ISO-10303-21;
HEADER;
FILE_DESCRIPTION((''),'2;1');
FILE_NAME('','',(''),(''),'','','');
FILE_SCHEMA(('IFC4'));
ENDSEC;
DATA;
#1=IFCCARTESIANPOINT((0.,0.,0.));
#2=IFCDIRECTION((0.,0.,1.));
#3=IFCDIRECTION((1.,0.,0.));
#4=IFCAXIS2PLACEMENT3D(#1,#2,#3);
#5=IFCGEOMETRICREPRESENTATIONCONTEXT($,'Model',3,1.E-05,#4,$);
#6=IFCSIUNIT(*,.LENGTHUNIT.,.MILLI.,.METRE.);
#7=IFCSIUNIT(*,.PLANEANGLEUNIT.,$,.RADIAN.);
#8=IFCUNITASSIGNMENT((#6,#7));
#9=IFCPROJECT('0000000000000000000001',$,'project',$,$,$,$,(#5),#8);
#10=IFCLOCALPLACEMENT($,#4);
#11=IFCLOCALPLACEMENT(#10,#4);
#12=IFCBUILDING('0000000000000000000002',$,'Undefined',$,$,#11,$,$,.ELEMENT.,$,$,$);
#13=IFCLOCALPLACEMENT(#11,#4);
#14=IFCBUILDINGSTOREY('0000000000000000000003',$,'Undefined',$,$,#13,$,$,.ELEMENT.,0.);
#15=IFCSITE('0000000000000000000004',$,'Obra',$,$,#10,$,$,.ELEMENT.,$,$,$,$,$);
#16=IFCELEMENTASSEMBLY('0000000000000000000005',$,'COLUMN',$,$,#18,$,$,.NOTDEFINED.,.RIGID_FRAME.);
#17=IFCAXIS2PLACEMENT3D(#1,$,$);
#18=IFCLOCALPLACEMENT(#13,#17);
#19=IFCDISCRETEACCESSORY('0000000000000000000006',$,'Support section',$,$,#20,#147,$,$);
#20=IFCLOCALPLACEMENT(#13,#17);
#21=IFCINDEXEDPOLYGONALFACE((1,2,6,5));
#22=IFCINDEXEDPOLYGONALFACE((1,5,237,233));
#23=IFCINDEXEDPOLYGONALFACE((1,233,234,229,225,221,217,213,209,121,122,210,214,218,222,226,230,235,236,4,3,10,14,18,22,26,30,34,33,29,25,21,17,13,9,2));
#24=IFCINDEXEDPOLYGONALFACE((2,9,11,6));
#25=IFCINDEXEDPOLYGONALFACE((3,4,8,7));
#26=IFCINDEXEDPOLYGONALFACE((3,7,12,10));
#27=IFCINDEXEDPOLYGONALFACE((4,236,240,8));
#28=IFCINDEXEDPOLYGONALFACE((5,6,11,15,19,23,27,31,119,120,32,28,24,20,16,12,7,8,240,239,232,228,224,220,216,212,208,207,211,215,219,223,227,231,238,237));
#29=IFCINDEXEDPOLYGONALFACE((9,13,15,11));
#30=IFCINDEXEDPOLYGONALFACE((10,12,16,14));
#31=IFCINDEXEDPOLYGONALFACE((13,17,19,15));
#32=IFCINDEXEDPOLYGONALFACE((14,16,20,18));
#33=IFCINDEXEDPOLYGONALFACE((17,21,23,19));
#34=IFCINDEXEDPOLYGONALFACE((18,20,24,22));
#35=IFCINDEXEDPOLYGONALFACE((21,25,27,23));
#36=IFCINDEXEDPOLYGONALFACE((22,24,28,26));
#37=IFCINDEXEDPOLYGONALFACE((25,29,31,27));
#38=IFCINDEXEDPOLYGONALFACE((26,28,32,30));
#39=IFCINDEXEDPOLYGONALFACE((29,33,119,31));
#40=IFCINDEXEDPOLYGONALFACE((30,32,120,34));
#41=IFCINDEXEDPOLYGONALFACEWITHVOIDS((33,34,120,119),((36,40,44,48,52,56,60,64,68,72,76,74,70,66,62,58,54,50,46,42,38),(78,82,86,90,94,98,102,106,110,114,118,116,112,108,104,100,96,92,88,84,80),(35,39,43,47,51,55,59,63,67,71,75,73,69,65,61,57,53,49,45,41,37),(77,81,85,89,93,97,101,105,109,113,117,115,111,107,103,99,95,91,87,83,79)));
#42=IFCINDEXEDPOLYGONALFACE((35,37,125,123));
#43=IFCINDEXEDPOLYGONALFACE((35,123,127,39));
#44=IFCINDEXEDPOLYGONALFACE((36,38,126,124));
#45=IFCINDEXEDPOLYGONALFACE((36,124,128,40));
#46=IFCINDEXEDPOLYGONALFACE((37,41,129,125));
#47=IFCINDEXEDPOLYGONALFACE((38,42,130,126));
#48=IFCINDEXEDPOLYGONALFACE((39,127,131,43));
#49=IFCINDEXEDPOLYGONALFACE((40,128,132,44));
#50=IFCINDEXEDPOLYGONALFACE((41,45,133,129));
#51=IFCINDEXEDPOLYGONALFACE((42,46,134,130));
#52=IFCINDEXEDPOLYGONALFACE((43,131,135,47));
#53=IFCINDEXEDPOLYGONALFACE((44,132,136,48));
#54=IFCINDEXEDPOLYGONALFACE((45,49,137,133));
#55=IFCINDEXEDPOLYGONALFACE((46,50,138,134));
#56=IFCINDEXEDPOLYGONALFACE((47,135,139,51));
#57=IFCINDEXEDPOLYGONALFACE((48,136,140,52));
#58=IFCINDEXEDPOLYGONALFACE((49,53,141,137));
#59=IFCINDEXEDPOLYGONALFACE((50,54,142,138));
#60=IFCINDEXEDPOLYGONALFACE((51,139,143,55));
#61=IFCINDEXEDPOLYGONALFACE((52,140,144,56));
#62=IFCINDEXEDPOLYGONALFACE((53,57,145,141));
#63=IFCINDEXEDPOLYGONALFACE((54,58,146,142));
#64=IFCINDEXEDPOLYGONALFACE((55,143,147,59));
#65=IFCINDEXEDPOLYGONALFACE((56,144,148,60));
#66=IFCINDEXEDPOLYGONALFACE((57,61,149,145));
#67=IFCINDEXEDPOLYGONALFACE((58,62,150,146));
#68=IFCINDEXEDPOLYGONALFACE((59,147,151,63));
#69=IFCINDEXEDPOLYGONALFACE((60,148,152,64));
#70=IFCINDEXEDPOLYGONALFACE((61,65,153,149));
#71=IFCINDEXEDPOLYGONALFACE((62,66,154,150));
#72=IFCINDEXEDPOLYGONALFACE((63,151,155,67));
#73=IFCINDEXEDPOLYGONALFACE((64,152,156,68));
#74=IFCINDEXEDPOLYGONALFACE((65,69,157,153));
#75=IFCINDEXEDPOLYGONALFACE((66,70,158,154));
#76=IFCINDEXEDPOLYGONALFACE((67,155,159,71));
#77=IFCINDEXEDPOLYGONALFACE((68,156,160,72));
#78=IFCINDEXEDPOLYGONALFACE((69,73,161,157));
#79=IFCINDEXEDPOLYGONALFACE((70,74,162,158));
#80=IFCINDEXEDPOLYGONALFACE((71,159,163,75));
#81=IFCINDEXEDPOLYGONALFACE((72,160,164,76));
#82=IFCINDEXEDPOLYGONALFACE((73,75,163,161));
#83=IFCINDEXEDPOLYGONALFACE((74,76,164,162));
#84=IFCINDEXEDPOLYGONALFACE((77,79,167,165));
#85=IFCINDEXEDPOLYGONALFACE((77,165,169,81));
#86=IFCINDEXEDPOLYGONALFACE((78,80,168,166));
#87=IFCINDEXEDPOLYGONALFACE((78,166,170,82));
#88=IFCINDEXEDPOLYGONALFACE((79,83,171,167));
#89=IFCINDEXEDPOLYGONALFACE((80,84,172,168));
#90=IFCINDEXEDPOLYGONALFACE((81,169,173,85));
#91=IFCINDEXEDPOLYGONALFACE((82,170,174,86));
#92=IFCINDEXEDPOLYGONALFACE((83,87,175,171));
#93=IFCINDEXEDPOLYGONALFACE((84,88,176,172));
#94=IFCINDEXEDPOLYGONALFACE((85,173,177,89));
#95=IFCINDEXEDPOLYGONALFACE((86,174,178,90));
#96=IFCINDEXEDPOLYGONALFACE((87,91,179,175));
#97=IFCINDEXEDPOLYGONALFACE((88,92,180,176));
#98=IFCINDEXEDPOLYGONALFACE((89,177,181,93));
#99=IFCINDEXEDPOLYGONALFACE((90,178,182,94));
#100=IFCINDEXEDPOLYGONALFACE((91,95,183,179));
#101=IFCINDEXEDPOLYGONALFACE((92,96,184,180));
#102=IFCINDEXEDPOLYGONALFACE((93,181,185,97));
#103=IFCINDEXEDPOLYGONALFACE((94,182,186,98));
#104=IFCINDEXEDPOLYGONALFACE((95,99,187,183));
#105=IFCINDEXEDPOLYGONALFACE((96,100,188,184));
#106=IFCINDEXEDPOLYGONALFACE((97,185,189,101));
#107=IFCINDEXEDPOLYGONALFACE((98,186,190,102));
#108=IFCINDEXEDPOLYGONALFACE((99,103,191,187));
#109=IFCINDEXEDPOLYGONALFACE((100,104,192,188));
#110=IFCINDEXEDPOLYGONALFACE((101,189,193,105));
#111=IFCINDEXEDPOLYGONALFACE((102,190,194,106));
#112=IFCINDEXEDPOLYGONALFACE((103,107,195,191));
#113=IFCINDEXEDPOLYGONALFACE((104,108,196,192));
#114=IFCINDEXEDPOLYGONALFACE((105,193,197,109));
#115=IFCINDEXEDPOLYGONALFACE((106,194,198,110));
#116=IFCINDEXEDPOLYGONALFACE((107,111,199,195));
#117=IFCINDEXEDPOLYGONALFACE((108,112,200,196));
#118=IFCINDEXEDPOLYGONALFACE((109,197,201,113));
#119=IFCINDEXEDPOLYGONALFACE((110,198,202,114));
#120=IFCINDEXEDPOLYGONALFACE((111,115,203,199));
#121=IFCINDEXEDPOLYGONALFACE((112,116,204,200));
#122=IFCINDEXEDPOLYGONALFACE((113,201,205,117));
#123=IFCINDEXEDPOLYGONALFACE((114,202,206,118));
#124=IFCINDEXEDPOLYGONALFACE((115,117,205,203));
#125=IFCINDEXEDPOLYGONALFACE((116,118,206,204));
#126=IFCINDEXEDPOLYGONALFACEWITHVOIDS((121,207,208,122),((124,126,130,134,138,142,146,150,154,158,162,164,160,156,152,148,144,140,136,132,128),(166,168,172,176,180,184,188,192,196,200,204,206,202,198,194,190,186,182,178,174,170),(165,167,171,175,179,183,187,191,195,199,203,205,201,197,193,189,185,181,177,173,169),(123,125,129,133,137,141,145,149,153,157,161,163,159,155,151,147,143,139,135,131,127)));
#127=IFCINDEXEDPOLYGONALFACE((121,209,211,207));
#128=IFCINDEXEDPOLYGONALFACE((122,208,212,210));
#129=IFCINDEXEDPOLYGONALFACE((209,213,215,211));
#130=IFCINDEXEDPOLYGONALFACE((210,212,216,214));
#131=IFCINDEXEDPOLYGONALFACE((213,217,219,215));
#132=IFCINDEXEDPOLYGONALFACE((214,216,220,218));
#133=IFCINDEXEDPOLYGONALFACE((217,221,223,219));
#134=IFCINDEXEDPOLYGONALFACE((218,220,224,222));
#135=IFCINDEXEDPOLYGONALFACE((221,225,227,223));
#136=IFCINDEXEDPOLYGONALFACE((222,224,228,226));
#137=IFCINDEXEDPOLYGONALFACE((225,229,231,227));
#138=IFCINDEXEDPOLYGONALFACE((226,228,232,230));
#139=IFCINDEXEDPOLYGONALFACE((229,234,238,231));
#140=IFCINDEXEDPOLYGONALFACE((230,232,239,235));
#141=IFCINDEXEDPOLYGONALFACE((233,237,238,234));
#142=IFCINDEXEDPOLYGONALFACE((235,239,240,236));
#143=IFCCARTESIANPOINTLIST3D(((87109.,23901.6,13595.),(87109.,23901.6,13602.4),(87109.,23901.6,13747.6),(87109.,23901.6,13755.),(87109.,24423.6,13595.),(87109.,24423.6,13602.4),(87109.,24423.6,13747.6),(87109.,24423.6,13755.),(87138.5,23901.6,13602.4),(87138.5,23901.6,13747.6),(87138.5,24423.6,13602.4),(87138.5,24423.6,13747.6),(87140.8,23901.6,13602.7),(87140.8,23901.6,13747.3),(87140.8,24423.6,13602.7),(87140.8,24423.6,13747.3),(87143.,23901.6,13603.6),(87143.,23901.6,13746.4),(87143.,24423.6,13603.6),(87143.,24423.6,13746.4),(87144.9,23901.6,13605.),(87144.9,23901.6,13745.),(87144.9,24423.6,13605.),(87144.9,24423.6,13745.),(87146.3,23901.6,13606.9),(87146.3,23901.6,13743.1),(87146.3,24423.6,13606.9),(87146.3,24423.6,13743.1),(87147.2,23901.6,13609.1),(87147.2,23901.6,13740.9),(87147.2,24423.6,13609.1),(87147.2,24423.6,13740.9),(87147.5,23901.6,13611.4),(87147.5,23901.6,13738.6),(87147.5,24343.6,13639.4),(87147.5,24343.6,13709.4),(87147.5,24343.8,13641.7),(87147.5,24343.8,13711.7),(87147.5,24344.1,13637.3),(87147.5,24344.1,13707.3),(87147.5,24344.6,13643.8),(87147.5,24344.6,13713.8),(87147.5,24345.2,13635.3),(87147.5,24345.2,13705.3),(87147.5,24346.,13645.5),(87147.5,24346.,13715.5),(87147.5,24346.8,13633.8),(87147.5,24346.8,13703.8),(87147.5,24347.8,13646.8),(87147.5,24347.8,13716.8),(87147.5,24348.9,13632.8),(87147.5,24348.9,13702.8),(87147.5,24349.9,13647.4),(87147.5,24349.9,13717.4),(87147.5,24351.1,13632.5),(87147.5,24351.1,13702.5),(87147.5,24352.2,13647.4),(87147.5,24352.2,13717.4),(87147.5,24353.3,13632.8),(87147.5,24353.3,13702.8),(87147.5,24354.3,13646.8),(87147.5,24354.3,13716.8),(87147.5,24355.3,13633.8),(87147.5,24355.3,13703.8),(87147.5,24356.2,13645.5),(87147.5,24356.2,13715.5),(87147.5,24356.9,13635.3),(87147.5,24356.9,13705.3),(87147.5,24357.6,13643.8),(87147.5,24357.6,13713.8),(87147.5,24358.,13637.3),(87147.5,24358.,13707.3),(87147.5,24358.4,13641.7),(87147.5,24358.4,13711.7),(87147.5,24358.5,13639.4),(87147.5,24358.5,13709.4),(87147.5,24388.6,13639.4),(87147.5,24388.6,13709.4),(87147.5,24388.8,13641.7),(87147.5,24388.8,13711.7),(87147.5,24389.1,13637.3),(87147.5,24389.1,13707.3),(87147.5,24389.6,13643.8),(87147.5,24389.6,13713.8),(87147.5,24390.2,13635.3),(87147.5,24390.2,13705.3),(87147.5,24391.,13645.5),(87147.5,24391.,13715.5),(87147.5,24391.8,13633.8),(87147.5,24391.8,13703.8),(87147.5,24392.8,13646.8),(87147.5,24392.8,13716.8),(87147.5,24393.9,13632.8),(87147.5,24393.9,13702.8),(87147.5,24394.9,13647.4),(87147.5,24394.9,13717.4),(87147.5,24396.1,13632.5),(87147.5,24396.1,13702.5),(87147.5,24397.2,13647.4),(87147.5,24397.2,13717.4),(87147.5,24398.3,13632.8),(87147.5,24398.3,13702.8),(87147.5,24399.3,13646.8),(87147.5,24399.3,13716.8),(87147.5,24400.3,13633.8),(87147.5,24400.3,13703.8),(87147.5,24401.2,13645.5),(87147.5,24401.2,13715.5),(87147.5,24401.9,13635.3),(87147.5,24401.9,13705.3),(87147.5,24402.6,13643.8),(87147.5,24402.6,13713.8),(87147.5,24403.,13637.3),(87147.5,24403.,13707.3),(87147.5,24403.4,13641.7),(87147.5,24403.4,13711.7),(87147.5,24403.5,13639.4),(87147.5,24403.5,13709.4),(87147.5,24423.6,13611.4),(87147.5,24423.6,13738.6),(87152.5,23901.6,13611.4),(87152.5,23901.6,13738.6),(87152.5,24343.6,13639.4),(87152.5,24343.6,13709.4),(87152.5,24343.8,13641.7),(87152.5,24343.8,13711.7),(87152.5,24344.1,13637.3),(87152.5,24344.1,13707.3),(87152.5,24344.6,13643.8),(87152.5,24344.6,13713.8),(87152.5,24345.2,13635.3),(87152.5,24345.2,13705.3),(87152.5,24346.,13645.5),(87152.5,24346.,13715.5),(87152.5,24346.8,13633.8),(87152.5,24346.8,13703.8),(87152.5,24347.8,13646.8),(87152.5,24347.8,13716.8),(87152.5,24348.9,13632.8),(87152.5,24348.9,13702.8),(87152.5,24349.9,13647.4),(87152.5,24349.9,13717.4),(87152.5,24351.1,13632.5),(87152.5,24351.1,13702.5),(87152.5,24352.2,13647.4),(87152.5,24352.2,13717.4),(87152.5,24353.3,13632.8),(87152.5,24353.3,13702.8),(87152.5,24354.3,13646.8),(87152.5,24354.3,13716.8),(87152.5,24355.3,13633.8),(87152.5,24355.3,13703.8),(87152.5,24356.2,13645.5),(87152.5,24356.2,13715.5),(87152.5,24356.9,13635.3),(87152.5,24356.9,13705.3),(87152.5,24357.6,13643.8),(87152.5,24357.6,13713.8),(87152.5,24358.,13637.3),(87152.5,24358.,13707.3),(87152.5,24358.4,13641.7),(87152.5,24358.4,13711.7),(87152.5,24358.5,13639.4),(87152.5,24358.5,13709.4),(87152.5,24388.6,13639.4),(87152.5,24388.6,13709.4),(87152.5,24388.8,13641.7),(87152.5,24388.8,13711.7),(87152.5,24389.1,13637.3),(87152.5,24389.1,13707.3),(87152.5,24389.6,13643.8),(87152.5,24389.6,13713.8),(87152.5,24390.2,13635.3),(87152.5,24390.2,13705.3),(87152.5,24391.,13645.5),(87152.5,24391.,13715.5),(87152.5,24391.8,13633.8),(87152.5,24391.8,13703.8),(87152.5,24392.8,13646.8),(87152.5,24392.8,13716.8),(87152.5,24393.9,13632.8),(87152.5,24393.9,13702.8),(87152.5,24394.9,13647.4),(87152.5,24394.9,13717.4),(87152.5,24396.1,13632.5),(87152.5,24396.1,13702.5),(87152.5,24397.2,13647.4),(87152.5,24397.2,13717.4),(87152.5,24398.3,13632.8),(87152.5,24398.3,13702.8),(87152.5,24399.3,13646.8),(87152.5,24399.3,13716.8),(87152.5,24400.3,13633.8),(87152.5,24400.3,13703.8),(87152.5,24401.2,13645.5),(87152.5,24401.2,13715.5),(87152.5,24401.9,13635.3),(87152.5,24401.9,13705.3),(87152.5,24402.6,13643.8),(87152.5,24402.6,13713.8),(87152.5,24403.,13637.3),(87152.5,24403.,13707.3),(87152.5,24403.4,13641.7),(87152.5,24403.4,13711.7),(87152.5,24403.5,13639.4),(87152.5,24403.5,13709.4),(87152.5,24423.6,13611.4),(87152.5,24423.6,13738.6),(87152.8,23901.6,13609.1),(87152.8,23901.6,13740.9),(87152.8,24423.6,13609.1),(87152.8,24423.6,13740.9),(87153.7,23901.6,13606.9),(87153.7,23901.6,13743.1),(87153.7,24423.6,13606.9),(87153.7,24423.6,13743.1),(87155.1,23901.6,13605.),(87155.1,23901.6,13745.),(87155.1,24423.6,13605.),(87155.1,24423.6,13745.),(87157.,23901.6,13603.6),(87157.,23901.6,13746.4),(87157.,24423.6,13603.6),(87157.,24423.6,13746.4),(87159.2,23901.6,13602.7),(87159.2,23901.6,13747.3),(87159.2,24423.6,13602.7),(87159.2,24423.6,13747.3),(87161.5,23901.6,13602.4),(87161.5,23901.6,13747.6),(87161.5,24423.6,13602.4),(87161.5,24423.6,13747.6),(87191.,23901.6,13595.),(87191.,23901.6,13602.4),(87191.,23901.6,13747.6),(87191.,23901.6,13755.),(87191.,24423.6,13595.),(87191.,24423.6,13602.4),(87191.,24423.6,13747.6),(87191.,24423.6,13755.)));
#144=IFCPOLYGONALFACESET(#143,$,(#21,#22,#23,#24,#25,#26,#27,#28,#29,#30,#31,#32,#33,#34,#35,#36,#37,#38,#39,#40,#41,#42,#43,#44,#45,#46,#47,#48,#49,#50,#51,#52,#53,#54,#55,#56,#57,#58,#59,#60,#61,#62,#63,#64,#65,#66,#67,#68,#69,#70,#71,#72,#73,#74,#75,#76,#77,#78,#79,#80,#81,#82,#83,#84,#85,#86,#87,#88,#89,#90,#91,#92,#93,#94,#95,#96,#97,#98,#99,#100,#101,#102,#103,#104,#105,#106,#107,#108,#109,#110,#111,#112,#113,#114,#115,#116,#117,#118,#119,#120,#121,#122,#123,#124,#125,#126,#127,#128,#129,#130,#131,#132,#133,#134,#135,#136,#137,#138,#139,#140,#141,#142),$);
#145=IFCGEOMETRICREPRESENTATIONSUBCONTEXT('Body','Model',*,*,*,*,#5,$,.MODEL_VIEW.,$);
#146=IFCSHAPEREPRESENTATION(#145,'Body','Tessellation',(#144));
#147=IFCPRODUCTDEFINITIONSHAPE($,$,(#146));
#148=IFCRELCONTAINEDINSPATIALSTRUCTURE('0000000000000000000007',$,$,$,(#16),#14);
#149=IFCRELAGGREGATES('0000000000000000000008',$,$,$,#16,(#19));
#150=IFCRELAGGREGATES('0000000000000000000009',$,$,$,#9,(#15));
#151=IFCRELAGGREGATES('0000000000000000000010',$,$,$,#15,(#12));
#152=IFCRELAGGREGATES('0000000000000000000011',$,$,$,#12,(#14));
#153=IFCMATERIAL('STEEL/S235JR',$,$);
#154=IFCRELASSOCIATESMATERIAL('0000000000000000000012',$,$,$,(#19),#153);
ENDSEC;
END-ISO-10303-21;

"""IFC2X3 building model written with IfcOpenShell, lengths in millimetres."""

from ifc_helpers import new_model, si_unit, frame, origin_with_axes, origin_2d_with_axis, place, context, subcontext, project, spatial, circle, i_section, extrude, clip, halfspace, source, transform, mapped, material, element, aggregate, save


model = new_model("IFC2X3")

# Units and contexts
model_context = context("Model", 3, precision=1e-05, world=origin_with_axes())
body_context = subcontext(model_context, "Body", "Model", "MODEL_VIEW")
ifc_project = project(units=[si_unit("LENGTHUNIT", "METRE", prefix="MILLI"), si_unit("PLANEANGLEUNIT", "RADIAN")], contexts=[model_context])

# Site, building, storey
site_placement = place(None, origin_with_axes())
site = spatial("IfcSite", under=ifc_project, at=site_placement, Name="Obra", CompositionType="ELEMENT")
building_placement = place(site_placement, origin_with_axes())
building = spatial("IfcBuilding", under=site, at=building_placement, Name="Undefined", CompositionType="ELEMENT")
storey_placement = place(building_placement, origin_with_axes())
storey = spatial("IfcBuildingStorey", under=building, at=storey_placement, Name="Undefined", CompositionType="ELEMENT", Elevation=0.0)

# Shared definitions
ifc_material_1 = material(Name="STEEL/S235JR")

# Element assembly
assembly_1_placement = place(storey_placement, origin_with_axes())
assembly_1 = element("IfcElementAssembly", 1, at=assembly_1_placement, inside=storey, Name="COLUMN", AssemblyPlace="NOTDEFINED", PredefinedType="RIGID_FRAME")

# Shared definitions
shared_shape_1 = source(origin_with_axes(), body_context, "Body", "SweptSolid", [
    extrude(circle(Radius=7.5, at=origin_2d_with_axis()), frame((0.0, -2.6, 0.0), z_axis=(0.0, 1.0, 0.0), x_axis=(1.0, 0.0, 0.0)), (0.0, 0.0, 1.0), 5.2),
])

# Discrete accessory, opening
discrete_accessory_1_placement = place(assembly_1_placement, frame((87150.0, 23901.0, 13675.0), z_axis=(0.0, 0.0, 1.0), x_axis=(0.0, 1.0, 0.0)))
discrete_accessory_1 = element("IfcDiscreteAccessory", 2, at=discrete_accessory_1_placement, material=ifc_material_1, Name="Support section", context=body_context, shape_type="Clipping", body=[
    clip(clip(extrude(i_section(OverallWidth=82.0, OverallDepth=160.0, WebThickness=5.0, FlangeThickness=7.4, FilletRadius=9.0, at=origin_2d_with_axis()), frame((522.6, 0.0, 0.0), z_axis=(-1.0, 0.0, 0.0), x_axis=(0.0, -1.0, 0.0)), (0.0, 0.0, 1.0), 522.0), halfspace(frame((522.6, 0.0, -180.0), z_axis=(-1.0, 0.0, 0.0), x_axis=(0.0, 1.0, 0.0)), True)), halfspace(frame((0.6, 0.0, 580.0), z_axis=(-1.0, 0.0, 0.0), x_axis=(0.0, -1.0, 0.0)), False)),
])
opening_1_placement = place(assembly_1_placement, frame((87150.0, 24373.6, 13710.0), z_axis=(0.0, -1.0, 0.0), x_axis=(0.0, 0.0, -1.0)))
element("IfcOpeningElement", 3, at=opening_1_placement, cuts=discrete_accessory_1, ObjectType="Opening", context=body_context, shape_type="MappedRepresentation", body=[
    mapped(shared_shape_1, transform((0.0, 0.0, -22.5))),
    mapped(shared_shape_1, transform((70.0, 0.0, -22.5))),
    mapped(shared_shape_1, transform((0.0, 0.0, 22.5))),
    mapped(shared_shape_1, transform((70.0, 0.0, 22.5))),
])

aggregate(assembly_1, [discrete_accessory_1])

save(model, "model.ifc")
